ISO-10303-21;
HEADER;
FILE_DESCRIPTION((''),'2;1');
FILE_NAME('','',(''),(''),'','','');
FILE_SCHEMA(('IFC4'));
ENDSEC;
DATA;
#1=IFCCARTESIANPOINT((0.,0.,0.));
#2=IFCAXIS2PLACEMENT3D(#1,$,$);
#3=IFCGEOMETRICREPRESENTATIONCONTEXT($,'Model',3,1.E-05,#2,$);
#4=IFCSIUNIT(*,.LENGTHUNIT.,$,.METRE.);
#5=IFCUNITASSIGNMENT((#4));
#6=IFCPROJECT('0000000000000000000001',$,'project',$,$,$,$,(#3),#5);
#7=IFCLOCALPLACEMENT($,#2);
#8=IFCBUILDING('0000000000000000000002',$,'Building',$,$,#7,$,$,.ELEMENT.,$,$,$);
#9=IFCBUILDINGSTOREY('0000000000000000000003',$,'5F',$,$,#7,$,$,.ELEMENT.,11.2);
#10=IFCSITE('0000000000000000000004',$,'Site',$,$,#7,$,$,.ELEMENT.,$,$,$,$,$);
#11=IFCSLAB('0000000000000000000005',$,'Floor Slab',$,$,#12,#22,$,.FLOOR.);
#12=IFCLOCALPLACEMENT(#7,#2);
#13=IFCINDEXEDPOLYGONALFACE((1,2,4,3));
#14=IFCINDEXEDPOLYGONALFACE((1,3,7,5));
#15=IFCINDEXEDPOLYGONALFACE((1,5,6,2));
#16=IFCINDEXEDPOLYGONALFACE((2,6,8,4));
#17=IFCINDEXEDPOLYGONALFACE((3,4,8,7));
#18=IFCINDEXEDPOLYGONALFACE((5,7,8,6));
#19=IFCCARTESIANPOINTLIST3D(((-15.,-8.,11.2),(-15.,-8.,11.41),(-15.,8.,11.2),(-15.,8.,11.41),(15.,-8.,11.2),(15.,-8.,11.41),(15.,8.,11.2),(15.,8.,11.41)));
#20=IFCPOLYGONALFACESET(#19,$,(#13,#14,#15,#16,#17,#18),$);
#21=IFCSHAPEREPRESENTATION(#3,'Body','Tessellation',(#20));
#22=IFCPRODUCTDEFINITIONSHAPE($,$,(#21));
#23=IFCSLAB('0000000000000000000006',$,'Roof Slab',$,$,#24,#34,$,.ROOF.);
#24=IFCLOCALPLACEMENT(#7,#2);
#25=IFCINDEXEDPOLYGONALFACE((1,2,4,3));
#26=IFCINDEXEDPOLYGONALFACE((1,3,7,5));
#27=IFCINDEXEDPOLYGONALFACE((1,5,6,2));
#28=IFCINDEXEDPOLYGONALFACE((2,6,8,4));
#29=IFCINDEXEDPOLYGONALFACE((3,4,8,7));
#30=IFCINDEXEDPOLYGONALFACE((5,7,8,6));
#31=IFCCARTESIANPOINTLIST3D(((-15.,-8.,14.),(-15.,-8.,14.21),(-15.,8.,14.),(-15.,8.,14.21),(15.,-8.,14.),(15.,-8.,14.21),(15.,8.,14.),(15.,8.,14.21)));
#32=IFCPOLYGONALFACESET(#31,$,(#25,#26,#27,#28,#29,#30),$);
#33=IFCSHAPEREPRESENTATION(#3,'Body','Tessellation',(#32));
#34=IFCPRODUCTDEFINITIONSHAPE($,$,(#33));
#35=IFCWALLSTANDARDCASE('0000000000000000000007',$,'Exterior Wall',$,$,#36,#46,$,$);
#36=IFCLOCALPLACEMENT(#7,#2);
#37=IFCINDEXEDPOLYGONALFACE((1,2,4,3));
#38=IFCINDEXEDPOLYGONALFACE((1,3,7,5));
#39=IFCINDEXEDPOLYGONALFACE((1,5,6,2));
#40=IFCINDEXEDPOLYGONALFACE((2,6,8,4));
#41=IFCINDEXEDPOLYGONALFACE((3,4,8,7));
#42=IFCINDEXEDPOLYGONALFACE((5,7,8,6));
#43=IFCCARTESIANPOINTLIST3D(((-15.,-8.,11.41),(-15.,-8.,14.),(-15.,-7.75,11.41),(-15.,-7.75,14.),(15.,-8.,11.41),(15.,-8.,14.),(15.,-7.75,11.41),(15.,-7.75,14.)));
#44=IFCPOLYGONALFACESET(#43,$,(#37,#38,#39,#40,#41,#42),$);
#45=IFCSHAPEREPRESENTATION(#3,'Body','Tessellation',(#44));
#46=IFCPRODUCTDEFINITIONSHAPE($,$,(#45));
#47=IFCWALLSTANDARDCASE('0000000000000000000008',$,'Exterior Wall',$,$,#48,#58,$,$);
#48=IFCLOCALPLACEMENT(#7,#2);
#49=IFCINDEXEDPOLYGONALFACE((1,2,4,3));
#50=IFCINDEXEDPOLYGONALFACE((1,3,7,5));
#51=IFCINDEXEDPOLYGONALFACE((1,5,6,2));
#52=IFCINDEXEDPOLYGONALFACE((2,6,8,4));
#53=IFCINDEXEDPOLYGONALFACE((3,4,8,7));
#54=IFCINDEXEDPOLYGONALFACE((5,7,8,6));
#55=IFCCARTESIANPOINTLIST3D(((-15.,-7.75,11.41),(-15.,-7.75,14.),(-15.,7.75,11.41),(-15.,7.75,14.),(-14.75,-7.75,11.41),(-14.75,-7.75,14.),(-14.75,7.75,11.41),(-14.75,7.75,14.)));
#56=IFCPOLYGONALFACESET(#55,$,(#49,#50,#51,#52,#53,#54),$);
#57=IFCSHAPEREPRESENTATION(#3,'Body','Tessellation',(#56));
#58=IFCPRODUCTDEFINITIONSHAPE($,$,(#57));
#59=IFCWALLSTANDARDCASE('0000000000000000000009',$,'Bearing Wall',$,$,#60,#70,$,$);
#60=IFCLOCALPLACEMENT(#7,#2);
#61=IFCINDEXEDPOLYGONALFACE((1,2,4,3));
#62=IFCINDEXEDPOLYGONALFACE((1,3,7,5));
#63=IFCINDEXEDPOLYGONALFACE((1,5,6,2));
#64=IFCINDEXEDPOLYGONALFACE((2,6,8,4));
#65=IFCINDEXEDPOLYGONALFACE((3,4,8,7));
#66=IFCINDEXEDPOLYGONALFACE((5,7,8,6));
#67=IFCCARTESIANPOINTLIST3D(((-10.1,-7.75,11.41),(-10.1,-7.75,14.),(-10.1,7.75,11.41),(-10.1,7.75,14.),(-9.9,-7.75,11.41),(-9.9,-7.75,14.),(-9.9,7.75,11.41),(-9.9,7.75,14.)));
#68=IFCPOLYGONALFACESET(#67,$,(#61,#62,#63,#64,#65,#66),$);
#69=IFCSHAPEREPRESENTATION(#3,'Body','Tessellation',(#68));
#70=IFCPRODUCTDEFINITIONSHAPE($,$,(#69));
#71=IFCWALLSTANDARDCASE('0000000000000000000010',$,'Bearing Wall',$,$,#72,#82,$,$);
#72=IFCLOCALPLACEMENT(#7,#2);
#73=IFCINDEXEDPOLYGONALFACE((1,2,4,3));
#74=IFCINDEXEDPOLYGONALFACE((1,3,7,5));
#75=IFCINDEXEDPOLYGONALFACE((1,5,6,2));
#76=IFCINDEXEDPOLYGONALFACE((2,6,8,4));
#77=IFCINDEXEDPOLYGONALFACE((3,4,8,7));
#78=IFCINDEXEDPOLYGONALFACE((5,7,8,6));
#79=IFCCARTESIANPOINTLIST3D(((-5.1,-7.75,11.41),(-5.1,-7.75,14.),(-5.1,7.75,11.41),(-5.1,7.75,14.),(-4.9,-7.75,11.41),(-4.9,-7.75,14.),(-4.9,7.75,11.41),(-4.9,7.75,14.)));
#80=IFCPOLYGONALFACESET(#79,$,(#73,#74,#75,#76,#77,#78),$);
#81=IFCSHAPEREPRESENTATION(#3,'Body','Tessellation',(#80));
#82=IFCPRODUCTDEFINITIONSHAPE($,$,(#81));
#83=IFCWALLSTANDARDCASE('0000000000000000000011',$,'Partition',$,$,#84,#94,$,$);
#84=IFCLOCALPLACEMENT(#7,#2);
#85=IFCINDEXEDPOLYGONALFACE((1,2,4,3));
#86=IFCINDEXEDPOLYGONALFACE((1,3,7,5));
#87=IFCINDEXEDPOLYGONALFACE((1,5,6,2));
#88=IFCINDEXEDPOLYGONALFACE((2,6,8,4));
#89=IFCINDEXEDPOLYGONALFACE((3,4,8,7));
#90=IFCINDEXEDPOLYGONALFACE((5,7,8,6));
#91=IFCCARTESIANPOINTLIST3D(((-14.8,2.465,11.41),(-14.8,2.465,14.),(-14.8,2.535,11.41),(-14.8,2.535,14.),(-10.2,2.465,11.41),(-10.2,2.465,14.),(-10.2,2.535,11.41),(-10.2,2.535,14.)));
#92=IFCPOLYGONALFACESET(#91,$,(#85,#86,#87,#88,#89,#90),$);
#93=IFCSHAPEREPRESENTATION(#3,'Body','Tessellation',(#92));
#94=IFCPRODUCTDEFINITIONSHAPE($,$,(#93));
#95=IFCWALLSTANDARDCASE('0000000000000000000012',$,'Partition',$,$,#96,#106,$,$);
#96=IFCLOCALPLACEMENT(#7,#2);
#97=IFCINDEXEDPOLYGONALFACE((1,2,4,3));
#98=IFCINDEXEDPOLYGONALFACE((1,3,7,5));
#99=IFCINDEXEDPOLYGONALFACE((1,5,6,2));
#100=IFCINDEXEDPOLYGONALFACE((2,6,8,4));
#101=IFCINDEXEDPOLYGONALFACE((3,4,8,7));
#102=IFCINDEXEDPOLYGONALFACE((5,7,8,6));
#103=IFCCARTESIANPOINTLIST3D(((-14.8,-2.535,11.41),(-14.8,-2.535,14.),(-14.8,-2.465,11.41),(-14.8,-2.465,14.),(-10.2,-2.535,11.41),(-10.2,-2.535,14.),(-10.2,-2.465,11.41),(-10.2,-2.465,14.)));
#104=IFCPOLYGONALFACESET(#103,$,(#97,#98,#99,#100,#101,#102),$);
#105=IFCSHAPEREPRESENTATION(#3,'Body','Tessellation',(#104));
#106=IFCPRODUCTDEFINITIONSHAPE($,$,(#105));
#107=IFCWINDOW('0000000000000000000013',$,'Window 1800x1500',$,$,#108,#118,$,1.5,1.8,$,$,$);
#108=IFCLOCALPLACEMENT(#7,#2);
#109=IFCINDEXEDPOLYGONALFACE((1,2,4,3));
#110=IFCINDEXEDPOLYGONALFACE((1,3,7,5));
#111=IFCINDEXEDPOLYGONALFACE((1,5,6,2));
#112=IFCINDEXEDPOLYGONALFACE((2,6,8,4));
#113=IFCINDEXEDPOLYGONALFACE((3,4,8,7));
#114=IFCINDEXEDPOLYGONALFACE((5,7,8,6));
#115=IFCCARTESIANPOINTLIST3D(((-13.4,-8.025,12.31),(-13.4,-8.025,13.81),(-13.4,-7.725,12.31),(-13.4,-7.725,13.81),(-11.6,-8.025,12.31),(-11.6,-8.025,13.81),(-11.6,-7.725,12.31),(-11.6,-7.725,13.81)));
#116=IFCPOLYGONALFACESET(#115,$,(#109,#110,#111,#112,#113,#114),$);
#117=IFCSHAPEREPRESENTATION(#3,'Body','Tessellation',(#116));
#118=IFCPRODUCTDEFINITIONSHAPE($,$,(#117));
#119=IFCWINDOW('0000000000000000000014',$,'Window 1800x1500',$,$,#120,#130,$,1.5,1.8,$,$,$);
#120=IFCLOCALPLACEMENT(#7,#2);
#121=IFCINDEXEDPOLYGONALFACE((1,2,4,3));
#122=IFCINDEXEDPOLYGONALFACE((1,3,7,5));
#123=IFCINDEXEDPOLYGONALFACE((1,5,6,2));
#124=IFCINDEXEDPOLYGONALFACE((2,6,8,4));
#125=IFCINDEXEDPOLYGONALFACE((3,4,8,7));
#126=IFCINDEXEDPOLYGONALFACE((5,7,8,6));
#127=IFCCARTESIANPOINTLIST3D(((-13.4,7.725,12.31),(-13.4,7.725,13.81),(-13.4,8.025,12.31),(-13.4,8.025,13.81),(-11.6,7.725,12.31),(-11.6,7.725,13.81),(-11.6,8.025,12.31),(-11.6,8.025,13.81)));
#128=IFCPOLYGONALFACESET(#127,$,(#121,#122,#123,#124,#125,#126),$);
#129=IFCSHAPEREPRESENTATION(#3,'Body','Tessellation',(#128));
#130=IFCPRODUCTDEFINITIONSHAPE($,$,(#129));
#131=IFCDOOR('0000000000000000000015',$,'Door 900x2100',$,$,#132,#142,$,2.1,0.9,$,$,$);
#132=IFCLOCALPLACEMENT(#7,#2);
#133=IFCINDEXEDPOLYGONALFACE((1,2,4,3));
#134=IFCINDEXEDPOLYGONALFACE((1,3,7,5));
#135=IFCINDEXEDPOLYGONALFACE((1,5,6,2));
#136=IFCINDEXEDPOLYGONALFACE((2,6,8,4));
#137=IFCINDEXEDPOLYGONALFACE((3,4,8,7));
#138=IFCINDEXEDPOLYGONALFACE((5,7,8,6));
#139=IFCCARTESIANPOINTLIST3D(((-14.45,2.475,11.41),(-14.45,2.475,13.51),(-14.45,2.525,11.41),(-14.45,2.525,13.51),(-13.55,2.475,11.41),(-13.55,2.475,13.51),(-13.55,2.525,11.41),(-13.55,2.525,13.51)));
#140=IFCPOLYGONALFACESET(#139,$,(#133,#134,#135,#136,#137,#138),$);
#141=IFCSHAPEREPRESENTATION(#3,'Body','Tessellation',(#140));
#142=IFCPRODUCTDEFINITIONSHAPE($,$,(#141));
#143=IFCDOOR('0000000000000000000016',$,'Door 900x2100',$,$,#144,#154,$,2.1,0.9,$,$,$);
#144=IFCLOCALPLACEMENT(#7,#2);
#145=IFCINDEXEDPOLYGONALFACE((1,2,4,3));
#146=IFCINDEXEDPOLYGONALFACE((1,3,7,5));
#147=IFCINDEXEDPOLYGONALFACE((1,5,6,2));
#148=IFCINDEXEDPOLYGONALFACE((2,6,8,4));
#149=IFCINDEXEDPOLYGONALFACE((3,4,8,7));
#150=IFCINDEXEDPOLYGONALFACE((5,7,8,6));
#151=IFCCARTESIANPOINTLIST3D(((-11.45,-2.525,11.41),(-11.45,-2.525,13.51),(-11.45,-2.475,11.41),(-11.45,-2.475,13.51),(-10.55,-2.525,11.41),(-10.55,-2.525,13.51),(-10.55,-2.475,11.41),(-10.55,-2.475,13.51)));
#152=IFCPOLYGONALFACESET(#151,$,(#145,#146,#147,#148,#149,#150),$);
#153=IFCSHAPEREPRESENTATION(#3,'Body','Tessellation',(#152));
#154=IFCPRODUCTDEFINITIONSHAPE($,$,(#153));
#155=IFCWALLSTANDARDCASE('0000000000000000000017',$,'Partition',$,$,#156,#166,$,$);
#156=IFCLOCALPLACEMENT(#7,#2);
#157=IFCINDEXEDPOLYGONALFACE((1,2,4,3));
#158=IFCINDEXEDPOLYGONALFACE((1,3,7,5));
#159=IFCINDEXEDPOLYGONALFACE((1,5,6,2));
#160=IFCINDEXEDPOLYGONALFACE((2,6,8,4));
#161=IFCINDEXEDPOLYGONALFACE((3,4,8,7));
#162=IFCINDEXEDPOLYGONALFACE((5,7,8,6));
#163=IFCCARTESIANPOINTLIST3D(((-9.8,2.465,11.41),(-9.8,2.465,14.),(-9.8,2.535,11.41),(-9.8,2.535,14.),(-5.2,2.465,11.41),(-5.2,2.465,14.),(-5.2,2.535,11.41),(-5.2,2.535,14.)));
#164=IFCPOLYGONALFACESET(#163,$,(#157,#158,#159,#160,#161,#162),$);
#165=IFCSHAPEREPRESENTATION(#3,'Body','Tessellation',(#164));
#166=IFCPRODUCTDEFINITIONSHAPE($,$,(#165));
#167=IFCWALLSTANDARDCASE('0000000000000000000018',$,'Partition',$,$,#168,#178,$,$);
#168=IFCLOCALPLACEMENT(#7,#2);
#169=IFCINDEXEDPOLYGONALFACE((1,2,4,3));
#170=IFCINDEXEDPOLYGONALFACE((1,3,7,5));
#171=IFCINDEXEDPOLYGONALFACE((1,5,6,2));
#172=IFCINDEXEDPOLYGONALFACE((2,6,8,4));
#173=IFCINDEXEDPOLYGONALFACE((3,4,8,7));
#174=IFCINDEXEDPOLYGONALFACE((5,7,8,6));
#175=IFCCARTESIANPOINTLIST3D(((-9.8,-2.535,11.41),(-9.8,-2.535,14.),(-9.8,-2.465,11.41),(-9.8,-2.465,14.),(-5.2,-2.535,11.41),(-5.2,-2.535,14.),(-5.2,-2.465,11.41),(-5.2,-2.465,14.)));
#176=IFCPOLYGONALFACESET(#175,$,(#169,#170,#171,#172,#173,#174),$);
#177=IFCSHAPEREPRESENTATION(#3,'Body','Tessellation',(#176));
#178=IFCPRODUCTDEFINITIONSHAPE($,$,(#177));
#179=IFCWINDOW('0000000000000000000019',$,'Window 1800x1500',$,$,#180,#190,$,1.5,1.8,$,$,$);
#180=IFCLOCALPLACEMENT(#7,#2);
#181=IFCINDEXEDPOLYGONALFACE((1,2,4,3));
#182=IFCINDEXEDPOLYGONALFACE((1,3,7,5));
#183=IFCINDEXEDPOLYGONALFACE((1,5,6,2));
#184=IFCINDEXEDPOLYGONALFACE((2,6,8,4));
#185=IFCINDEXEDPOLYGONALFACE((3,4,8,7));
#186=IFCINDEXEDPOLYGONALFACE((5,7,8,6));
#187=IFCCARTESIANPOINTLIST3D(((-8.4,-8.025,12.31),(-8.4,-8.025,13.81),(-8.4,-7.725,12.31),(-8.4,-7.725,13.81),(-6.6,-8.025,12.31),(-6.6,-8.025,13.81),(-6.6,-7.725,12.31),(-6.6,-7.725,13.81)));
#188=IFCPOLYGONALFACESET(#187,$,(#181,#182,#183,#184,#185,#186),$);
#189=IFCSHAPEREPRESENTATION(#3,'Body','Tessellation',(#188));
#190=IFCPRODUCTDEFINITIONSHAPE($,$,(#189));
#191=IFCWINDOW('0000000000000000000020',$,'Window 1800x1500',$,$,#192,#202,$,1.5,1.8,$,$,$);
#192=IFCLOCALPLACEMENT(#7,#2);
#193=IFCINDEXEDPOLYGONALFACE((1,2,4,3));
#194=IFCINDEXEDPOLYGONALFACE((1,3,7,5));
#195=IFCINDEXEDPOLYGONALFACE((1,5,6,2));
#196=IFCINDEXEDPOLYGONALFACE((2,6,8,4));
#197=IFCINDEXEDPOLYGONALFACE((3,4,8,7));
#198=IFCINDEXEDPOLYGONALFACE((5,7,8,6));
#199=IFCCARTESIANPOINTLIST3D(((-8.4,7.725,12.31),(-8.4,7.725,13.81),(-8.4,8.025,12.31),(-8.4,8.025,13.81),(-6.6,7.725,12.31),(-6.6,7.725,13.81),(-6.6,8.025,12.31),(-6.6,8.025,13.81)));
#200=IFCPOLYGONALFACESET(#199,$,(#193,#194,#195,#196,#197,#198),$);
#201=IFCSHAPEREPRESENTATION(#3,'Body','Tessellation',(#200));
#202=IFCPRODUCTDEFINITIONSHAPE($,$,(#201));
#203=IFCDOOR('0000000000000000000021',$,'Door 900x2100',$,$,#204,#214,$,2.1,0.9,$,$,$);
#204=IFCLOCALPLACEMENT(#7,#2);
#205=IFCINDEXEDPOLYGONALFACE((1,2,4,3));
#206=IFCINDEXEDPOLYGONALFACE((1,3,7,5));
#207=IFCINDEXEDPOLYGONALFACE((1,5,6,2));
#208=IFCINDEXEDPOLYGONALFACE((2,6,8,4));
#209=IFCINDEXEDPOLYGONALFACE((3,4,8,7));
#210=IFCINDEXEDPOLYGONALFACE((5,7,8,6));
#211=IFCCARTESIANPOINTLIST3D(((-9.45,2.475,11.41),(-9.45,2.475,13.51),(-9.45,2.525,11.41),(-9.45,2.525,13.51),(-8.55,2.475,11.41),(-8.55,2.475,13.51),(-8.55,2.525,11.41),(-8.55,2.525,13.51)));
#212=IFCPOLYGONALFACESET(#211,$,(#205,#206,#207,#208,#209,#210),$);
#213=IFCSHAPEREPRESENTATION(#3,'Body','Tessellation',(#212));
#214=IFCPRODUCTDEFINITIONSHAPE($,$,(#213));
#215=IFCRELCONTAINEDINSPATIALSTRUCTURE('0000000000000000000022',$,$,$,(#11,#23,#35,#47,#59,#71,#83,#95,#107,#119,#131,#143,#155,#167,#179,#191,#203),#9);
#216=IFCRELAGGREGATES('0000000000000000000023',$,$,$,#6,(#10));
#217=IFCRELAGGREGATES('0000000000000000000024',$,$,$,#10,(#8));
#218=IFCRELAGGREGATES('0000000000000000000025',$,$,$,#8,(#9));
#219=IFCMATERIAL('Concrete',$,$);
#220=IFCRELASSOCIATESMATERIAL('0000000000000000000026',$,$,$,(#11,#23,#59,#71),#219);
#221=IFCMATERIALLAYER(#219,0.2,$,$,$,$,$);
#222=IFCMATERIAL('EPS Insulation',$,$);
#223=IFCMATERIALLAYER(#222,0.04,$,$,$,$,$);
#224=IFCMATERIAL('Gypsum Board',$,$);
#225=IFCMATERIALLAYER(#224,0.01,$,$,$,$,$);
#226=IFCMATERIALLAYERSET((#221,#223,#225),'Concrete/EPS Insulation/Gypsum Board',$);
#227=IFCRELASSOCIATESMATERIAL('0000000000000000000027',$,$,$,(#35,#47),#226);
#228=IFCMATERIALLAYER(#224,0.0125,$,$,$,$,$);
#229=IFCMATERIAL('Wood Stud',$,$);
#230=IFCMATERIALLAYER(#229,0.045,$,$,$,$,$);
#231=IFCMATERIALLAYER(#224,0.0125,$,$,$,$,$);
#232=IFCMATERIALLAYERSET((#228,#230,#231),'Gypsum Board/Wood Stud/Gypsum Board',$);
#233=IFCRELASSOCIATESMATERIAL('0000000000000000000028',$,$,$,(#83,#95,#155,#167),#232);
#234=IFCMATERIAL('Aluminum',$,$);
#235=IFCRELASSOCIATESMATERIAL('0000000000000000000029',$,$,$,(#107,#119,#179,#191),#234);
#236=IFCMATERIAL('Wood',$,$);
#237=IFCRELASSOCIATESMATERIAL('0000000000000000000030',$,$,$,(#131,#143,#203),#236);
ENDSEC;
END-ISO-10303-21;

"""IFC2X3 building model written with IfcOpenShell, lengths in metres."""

from ifc_helpers import new_model, si_unit, frame, origin, origin_2d, place, context, project, spatial, rectangle, extrude, material, layer, layer_set, layer_usage, element, save


model = new_model("IFC2X3")

# Units and contexts
model_context = context("Model", 3, precision=1e-05, world=origin())
ifc_project = project(units=[si_unit("LENGTHUNIT", "METRE")], contexts=[model_context])

# Site, building, storey
placement = place(None, origin())
site = spatial("IfcSite", under=ifc_project, at=placement, Name="Site", CompositionType="ELEMENT")
building = spatial("IfcBuilding", under=site, at=placement, Name="Building", CompositionType="ELEMENT")
storey = spatial("IfcBuildingStorey", under=building, at=placement, Name="5F", CompositionType="ELEMENT", Elevation=11.2)

# Slabs
ifc_material_1 = material(Name="Concrete")
slab_1_placement = place(None, frame((0.0, 0.0, 11.2)))
element("IfcSlab", 1, at=slab_1_placement, inside=storey, material=ifc_material_1, Name="Floor Slab", PredefinedType="FLOOR", context=model_context, shape_type="SweptSolid", body=[
    extrude(rectangle(XDim=30.0, YDim=16.0, at=origin_2d()), origin(), (0.0, 0.0, 1.0), 0.21),
])
slab_2_placement = place(None, frame((0.0, 0.0, 14.0)))
element("IfcSlab", 2, at=slab_2_placement, inside=storey, material=ifc_material_1, Name="Roof Slab", PredefinedType="ROOF", context=model_context, shape_type="SweptSolid", body=[
    extrude(rectangle(XDim=30.0, YDim=16.0, at=origin_2d()), origin(), (0.0, 0.0, 1.0), 0.21),
])

# Walls
ifc_layer_1 = layer(ifc_material_1, 0.2)
ifc_material_2 = material(Name="EPS Insulation")
ifc_layer_2 = layer(ifc_material_2, 0.04)
ifc_material_3 = material(Name="Gypsum Board")
ifc_layer_3 = layer(ifc_material_3, 0.01)
ifc_layer_set_1 = layer_set([ifc_layer_1, ifc_layer_2, ifc_layer_3], Name="Concrete/EPS Insulation/Gypsum Board")
ifc_layer_usage_1 = layer_usage(ifc_layer_set_1, "AXIS2", "POSITIVE", 0.0)
wall_1_placement = place(None, frame((0.0, -7.875, 11.41)))
element("IfcWallStandardCase", 3, at=wall_1_placement, inside=storey, material=ifc_layer_usage_1, Name="Exterior Wall", context=model_context, shape_type="SweptSolid", body=[
    extrude(rectangle(XDim=30.0, YDim=0.25, at=origin_2d()), origin(), (0.0, 0.0, 1.0), 2.59),
])
wall_2_placement = place(None, frame((-14.875, 0.0, 11.41)))
element("IfcWallStandardCase", 4, at=wall_2_placement, inside=storey, material=ifc_layer_usage_1, Name="Exterior Wall", context=model_context, shape_type="SweptSolid", body=[
    extrude(rectangle(XDim=0.25, YDim=15.5, at=origin_2d()), origin(), (0.0, 0.0, 1.0), 2.59),
])
for number, where, name in (
    (5, (-10.0, 0.0, 11.41), "Bearing Wall"),
    (6, (-5.0, 0.0, 11.41), "Bearing Wall"),
):
    element("IfcWallStandardCase", number, at=place(None, frame(where)), inside=storey, material=ifc_material_1, Name=name, context=model_context, shape_type="SweptSolid", body=[
        extrude(rectangle(XDim=0.2, YDim=15.5, at=origin_2d()), origin(), (0.0, 0.0, 1.0), 2.59),
    ])
ifc_layer_4 = layer(ifc_material_3, 0.0125)
ifc_material_4 = material(Name="Wood Stud")
ifc_layer_5 = layer(ifc_material_4, 0.045)
ifc_layer_6 = layer(ifc_material_3, 0.0125)
ifc_layer_set_2 = layer_set([ifc_layer_4, ifc_layer_5, ifc_layer_6], Name="Gypsum Board/Wood Stud/Gypsum Board")
ifc_layer_usage_2 = layer_usage(ifc_layer_set_2, "AXIS2", "POSITIVE", 0.0)
for number, where, name in (
    (7, (-12.5, 2.5, 11.41), "Partition"),
    (8, (-12.5, -2.5, 11.41), "Partition"),
):
    element("IfcWallStandardCase", number, at=place(None, frame(where)), inside=storey, material=ifc_layer_usage_2, Name=name, context=model_context, shape_type="SweptSolid", body=[
        extrude(rectangle(XDim=4.6, YDim=0.07, at=origin_2d()), origin(), (0.0, 0.0, 1.0), 2.59),
    ])

# Windows
ifc_material_5 = material(Name="Aluminum")
for number, where, name in (
    (9, (-12.5, -7.875, 12.31), "Window 1800x1500"),
    (10, (-12.5, 7.875, 12.31), "Window 1800x1500"),
):
    element("IfcWindow", number, at=place(None, frame(where)), inside=storey, material=ifc_material_5, Name=name, OverallHeight=1.5, OverallWidth=1.8, context=model_context, shape_type="SweptSolid", body=[
        extrude(rectangle(XDim=1.8, YDim=0.3, at=origin_2d()), origin(), (0.0, 0.0, 1.0), 1.5),
    ])

# Doors
ifc_material_6 = material(Name="Wood")
for number, where, name in (
    (11, (-14.0, 2.5, 11.41), "Door 900x2100"),
    (12, (-11.0, -2.5, 11.41), "Door 900x2100"),
):
    element("IfcDoor", number, at=place(None, frame(where)), inside=storey, material=ifc_material_6, Name=name, OverallHeight=2.1, OverallWidth=0.9, context=model_context, shape_type="SweptSolid", body=[
        extrude(rectangle(XDim=0.9, YDim=0.05, at=origin_2d()), origin(), (0.0, 0.0, 1.0), 2.1),
    ])

# Walls
for number, where, name in (
    (13, (-7.5, 2.5, 11.41), "Partition"),
    (14, (-7.5, -2.5, 11.41), "Partition"),
):
    element("IfcWallStandardCase", number, at=place(None, frame(where)), inside=storey, material=ifc_layer_usage_2, Name=name, context=model_context, shape_type="SweptSolid", body=[
        extrude(rectangle(XDim=4.6, YDim=0.07, at=origin_2d()), origin(), (0.0, 0.0, 1.0), 2.59),
    ])

# Windows
for number, where, name in (
    (15, (-7.5, -7.875, 12.31), "Window 1800x1500"),
    (16, (-7.5, 7.875, 12.31), "Window 1800x1500"),
):
    element("IfcWindow", number, at=place(None, frame(where)), inside=storey, material=ifc_material_5, Name=name, OverallHeight=1.5, OverallWidth=1.8, context=model_context, shape_type="SweptSolid", body=[
        extrude(rectangle(XDim=1.8, YDim=0.3, at=origin_2d()), origin(), (0.0, 0.0, 1.0), 1.5),
    ])

# Door
for number, where, name in (
    (17, (-9.0, 2.5, 11.41), "Door 900x2100"),
):
    element("IfcDoor", number, at=place(None, frame(where)), inside=storey, material=ifc_material_6, Name=name, OverallHeight=2.1, OverallWidth=0.9, context=model_context, shape_type="SweptSolid", body=[
        extrude(rectangle(XDim=0.9, YDim=0.05, at=origin_2d()), origin(), (0.0, 0.0, 1.0), 2.1),
    ])

save(model, "model.ifc")
